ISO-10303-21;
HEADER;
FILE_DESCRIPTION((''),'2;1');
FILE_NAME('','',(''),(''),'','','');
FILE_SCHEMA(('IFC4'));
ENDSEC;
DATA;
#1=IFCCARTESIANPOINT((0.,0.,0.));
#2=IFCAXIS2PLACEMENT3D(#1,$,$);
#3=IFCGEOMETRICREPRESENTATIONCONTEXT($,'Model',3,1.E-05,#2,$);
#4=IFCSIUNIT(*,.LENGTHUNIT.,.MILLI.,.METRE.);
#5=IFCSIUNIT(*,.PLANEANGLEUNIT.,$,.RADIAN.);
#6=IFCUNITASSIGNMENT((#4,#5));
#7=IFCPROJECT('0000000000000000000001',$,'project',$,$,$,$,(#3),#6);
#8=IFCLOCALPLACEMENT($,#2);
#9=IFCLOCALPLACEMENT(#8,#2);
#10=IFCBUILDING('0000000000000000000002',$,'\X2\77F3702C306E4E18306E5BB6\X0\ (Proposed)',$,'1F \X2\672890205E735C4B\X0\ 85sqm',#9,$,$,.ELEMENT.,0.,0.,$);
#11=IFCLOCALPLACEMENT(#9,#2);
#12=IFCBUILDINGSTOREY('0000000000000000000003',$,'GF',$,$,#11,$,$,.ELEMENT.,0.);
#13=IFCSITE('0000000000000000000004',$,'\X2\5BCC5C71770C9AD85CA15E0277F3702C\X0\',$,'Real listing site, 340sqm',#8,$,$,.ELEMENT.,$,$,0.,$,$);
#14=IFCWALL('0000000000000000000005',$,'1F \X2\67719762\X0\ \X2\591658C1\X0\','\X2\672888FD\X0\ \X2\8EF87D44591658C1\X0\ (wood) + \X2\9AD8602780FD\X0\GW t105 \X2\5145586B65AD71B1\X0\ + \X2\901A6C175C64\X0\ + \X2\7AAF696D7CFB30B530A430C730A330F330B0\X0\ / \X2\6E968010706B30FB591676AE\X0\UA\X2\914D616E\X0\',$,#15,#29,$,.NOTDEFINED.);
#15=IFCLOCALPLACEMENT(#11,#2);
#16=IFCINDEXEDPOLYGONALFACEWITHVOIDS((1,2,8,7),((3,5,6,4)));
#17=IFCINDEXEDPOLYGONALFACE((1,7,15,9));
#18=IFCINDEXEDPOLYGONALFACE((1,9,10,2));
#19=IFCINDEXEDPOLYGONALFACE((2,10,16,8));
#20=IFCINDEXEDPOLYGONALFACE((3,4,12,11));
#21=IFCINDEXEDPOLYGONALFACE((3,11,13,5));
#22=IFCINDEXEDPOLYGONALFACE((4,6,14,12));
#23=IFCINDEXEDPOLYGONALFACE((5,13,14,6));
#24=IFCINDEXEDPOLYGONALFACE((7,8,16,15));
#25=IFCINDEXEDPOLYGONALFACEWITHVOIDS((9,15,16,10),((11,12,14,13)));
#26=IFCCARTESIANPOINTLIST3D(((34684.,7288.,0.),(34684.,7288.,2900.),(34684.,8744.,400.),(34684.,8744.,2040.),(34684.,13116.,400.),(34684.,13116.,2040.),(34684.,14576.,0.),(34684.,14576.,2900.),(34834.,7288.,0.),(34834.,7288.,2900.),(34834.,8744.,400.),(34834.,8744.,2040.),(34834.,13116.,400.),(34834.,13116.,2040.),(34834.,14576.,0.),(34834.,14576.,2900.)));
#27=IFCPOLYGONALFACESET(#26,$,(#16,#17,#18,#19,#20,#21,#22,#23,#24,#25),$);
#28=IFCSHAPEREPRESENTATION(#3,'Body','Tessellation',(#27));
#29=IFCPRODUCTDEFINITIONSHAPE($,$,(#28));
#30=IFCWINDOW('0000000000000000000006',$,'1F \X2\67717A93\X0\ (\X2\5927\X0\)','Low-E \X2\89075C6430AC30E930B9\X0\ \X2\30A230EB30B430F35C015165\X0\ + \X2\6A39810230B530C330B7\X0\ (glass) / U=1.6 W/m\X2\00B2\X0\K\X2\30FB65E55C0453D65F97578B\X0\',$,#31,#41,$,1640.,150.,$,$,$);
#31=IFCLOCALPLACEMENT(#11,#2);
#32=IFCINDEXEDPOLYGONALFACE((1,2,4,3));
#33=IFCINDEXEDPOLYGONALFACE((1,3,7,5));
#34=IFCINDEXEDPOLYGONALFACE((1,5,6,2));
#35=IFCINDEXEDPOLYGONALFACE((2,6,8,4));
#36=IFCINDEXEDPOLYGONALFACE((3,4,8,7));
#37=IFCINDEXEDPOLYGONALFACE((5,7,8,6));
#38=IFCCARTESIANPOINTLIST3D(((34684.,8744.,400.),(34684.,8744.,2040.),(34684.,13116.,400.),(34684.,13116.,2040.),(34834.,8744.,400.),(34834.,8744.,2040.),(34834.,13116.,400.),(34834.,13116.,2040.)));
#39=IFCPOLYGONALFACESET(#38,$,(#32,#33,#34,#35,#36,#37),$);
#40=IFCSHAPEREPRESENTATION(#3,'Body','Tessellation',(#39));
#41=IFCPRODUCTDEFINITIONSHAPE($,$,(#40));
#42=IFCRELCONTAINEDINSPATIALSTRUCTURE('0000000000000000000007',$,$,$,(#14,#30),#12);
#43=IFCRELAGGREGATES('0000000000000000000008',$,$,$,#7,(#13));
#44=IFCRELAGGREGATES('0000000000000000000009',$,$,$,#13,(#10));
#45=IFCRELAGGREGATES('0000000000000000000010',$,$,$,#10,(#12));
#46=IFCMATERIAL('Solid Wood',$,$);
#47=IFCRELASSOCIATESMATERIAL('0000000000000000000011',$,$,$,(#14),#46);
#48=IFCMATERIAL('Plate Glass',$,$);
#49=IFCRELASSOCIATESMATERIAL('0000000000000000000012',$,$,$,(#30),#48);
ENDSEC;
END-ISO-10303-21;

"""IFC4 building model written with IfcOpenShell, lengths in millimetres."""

from ifc_helpers import new_model, si_unit, frame, frame_2d, origin, place, context, project, spatial, rectangle, extrude, material, element, fill, save


model = new_model("IFC4")

# Units and contexts
model_context = context("Model", 3, precision=1e-05, world=origin())
ifc_project = project(units=[si_unit("LENGTHUNIT", "METRE", prefix="MILLI"), si_unit("PLANEANGLEUNIT", "RADIAN")], contexts=[model_context])

# Site, building, storey
site_placement = place(None, origin())
site = spatial("IfcSite", under=ifc_project, at=site_placement, Name="富山県高岡市石瀬", ObjectType="Real listing site, 340sqm", CompositionType="ELEMENT", RefElevation=0.0)
building_placement = place(site_placement, origin())
building = spatial("IfcBuilding", under=site, at=building_placement, Name="石瀬の丘の家 (Proposed)", ObjectType="1F 木造平屋 85sqm", CompositionType="ELEMENT", ElevationOfRefHeight=0.0, ElevationOfTerrain=0.0)
storey_placement = place(building_placement, origin())
storey = spatial("IfcBuildingStorey", under=building, at=storey_placement, Name="GF", CompositionType="ELEMENT", Elevation=0.0)

# Shared definitions
ifc_material_1 = material(Name="Solid Wood")

# Wall, opening, window
wall_1_placement = place(storey_placement, frame((17342.0, 3644.0, 0.0)))
wall_1 = element("IfcWall", 1, at=wall_1_placement, inside=storey, material=ifc_material_1, Name="1F 東面 外壁", Description="木製 軸組外壁 (wood) + 高性能GW t105 充填断熱 + 通気層 + 窯業系サイディング / 準耐火・外皮UA配慮", PredefinedType="NOTDEFINED", context=model_context, shape_type="SweptSolid", body=[
    extrude(rectangle(XDim=150.0, YDim=7288.0, at=frame_2d((75.0, 3644.0))), frame((17342.0, 3644.0, 0.0)), (0.0, 0.0, 1.0), 2900.0),
])
opening_placement = place(storey_placement, frame((17342.0, 4372.0, 200.0)))
opening = element("IfcOpeningElement", 2, at=opening_placement, cuts=wall_1, PredefinedType="NOTDEFINED", context=model_context, shape_type="SweptSolid", body=[
    extrude(rectangle(XDim=150.0, YDim=4372.0, at=frame_2d((75.0, 2186.0))), frame((17342.0, 4372.0, 200.0)), (0.0, 0.0, 1.0), 1640.0),
])
ifc_material_2 = material(Name="Plate Glass")
window_placement = place(storey_placement, frame((17342.0, 4372.0, 200.0)))
window = element("IfcWindow", 3, at=window_placement, inside=storey, material=ifc_material_2, Name="1F 東窓 (大)", Description="Low-E 複層ガラス アルゴン封入 + 樹脂サッシ (glass) / U=1.6 W/m²K・日射取得型", OverallHeight=1640.0, OverallWidth=150.0, context=model_context, shape_type="SweptSolid", body=[
    extrude(rectangle(XDim=150.0, YDim=4372.0, at=frame_2d((75.0, 2186.0))), frame((17342.0, 4372.0, 200.0)), (0.0, 0.0, 1.0), 1640.0),
])
fill(opening, window)

save(model, "model.ifc")
